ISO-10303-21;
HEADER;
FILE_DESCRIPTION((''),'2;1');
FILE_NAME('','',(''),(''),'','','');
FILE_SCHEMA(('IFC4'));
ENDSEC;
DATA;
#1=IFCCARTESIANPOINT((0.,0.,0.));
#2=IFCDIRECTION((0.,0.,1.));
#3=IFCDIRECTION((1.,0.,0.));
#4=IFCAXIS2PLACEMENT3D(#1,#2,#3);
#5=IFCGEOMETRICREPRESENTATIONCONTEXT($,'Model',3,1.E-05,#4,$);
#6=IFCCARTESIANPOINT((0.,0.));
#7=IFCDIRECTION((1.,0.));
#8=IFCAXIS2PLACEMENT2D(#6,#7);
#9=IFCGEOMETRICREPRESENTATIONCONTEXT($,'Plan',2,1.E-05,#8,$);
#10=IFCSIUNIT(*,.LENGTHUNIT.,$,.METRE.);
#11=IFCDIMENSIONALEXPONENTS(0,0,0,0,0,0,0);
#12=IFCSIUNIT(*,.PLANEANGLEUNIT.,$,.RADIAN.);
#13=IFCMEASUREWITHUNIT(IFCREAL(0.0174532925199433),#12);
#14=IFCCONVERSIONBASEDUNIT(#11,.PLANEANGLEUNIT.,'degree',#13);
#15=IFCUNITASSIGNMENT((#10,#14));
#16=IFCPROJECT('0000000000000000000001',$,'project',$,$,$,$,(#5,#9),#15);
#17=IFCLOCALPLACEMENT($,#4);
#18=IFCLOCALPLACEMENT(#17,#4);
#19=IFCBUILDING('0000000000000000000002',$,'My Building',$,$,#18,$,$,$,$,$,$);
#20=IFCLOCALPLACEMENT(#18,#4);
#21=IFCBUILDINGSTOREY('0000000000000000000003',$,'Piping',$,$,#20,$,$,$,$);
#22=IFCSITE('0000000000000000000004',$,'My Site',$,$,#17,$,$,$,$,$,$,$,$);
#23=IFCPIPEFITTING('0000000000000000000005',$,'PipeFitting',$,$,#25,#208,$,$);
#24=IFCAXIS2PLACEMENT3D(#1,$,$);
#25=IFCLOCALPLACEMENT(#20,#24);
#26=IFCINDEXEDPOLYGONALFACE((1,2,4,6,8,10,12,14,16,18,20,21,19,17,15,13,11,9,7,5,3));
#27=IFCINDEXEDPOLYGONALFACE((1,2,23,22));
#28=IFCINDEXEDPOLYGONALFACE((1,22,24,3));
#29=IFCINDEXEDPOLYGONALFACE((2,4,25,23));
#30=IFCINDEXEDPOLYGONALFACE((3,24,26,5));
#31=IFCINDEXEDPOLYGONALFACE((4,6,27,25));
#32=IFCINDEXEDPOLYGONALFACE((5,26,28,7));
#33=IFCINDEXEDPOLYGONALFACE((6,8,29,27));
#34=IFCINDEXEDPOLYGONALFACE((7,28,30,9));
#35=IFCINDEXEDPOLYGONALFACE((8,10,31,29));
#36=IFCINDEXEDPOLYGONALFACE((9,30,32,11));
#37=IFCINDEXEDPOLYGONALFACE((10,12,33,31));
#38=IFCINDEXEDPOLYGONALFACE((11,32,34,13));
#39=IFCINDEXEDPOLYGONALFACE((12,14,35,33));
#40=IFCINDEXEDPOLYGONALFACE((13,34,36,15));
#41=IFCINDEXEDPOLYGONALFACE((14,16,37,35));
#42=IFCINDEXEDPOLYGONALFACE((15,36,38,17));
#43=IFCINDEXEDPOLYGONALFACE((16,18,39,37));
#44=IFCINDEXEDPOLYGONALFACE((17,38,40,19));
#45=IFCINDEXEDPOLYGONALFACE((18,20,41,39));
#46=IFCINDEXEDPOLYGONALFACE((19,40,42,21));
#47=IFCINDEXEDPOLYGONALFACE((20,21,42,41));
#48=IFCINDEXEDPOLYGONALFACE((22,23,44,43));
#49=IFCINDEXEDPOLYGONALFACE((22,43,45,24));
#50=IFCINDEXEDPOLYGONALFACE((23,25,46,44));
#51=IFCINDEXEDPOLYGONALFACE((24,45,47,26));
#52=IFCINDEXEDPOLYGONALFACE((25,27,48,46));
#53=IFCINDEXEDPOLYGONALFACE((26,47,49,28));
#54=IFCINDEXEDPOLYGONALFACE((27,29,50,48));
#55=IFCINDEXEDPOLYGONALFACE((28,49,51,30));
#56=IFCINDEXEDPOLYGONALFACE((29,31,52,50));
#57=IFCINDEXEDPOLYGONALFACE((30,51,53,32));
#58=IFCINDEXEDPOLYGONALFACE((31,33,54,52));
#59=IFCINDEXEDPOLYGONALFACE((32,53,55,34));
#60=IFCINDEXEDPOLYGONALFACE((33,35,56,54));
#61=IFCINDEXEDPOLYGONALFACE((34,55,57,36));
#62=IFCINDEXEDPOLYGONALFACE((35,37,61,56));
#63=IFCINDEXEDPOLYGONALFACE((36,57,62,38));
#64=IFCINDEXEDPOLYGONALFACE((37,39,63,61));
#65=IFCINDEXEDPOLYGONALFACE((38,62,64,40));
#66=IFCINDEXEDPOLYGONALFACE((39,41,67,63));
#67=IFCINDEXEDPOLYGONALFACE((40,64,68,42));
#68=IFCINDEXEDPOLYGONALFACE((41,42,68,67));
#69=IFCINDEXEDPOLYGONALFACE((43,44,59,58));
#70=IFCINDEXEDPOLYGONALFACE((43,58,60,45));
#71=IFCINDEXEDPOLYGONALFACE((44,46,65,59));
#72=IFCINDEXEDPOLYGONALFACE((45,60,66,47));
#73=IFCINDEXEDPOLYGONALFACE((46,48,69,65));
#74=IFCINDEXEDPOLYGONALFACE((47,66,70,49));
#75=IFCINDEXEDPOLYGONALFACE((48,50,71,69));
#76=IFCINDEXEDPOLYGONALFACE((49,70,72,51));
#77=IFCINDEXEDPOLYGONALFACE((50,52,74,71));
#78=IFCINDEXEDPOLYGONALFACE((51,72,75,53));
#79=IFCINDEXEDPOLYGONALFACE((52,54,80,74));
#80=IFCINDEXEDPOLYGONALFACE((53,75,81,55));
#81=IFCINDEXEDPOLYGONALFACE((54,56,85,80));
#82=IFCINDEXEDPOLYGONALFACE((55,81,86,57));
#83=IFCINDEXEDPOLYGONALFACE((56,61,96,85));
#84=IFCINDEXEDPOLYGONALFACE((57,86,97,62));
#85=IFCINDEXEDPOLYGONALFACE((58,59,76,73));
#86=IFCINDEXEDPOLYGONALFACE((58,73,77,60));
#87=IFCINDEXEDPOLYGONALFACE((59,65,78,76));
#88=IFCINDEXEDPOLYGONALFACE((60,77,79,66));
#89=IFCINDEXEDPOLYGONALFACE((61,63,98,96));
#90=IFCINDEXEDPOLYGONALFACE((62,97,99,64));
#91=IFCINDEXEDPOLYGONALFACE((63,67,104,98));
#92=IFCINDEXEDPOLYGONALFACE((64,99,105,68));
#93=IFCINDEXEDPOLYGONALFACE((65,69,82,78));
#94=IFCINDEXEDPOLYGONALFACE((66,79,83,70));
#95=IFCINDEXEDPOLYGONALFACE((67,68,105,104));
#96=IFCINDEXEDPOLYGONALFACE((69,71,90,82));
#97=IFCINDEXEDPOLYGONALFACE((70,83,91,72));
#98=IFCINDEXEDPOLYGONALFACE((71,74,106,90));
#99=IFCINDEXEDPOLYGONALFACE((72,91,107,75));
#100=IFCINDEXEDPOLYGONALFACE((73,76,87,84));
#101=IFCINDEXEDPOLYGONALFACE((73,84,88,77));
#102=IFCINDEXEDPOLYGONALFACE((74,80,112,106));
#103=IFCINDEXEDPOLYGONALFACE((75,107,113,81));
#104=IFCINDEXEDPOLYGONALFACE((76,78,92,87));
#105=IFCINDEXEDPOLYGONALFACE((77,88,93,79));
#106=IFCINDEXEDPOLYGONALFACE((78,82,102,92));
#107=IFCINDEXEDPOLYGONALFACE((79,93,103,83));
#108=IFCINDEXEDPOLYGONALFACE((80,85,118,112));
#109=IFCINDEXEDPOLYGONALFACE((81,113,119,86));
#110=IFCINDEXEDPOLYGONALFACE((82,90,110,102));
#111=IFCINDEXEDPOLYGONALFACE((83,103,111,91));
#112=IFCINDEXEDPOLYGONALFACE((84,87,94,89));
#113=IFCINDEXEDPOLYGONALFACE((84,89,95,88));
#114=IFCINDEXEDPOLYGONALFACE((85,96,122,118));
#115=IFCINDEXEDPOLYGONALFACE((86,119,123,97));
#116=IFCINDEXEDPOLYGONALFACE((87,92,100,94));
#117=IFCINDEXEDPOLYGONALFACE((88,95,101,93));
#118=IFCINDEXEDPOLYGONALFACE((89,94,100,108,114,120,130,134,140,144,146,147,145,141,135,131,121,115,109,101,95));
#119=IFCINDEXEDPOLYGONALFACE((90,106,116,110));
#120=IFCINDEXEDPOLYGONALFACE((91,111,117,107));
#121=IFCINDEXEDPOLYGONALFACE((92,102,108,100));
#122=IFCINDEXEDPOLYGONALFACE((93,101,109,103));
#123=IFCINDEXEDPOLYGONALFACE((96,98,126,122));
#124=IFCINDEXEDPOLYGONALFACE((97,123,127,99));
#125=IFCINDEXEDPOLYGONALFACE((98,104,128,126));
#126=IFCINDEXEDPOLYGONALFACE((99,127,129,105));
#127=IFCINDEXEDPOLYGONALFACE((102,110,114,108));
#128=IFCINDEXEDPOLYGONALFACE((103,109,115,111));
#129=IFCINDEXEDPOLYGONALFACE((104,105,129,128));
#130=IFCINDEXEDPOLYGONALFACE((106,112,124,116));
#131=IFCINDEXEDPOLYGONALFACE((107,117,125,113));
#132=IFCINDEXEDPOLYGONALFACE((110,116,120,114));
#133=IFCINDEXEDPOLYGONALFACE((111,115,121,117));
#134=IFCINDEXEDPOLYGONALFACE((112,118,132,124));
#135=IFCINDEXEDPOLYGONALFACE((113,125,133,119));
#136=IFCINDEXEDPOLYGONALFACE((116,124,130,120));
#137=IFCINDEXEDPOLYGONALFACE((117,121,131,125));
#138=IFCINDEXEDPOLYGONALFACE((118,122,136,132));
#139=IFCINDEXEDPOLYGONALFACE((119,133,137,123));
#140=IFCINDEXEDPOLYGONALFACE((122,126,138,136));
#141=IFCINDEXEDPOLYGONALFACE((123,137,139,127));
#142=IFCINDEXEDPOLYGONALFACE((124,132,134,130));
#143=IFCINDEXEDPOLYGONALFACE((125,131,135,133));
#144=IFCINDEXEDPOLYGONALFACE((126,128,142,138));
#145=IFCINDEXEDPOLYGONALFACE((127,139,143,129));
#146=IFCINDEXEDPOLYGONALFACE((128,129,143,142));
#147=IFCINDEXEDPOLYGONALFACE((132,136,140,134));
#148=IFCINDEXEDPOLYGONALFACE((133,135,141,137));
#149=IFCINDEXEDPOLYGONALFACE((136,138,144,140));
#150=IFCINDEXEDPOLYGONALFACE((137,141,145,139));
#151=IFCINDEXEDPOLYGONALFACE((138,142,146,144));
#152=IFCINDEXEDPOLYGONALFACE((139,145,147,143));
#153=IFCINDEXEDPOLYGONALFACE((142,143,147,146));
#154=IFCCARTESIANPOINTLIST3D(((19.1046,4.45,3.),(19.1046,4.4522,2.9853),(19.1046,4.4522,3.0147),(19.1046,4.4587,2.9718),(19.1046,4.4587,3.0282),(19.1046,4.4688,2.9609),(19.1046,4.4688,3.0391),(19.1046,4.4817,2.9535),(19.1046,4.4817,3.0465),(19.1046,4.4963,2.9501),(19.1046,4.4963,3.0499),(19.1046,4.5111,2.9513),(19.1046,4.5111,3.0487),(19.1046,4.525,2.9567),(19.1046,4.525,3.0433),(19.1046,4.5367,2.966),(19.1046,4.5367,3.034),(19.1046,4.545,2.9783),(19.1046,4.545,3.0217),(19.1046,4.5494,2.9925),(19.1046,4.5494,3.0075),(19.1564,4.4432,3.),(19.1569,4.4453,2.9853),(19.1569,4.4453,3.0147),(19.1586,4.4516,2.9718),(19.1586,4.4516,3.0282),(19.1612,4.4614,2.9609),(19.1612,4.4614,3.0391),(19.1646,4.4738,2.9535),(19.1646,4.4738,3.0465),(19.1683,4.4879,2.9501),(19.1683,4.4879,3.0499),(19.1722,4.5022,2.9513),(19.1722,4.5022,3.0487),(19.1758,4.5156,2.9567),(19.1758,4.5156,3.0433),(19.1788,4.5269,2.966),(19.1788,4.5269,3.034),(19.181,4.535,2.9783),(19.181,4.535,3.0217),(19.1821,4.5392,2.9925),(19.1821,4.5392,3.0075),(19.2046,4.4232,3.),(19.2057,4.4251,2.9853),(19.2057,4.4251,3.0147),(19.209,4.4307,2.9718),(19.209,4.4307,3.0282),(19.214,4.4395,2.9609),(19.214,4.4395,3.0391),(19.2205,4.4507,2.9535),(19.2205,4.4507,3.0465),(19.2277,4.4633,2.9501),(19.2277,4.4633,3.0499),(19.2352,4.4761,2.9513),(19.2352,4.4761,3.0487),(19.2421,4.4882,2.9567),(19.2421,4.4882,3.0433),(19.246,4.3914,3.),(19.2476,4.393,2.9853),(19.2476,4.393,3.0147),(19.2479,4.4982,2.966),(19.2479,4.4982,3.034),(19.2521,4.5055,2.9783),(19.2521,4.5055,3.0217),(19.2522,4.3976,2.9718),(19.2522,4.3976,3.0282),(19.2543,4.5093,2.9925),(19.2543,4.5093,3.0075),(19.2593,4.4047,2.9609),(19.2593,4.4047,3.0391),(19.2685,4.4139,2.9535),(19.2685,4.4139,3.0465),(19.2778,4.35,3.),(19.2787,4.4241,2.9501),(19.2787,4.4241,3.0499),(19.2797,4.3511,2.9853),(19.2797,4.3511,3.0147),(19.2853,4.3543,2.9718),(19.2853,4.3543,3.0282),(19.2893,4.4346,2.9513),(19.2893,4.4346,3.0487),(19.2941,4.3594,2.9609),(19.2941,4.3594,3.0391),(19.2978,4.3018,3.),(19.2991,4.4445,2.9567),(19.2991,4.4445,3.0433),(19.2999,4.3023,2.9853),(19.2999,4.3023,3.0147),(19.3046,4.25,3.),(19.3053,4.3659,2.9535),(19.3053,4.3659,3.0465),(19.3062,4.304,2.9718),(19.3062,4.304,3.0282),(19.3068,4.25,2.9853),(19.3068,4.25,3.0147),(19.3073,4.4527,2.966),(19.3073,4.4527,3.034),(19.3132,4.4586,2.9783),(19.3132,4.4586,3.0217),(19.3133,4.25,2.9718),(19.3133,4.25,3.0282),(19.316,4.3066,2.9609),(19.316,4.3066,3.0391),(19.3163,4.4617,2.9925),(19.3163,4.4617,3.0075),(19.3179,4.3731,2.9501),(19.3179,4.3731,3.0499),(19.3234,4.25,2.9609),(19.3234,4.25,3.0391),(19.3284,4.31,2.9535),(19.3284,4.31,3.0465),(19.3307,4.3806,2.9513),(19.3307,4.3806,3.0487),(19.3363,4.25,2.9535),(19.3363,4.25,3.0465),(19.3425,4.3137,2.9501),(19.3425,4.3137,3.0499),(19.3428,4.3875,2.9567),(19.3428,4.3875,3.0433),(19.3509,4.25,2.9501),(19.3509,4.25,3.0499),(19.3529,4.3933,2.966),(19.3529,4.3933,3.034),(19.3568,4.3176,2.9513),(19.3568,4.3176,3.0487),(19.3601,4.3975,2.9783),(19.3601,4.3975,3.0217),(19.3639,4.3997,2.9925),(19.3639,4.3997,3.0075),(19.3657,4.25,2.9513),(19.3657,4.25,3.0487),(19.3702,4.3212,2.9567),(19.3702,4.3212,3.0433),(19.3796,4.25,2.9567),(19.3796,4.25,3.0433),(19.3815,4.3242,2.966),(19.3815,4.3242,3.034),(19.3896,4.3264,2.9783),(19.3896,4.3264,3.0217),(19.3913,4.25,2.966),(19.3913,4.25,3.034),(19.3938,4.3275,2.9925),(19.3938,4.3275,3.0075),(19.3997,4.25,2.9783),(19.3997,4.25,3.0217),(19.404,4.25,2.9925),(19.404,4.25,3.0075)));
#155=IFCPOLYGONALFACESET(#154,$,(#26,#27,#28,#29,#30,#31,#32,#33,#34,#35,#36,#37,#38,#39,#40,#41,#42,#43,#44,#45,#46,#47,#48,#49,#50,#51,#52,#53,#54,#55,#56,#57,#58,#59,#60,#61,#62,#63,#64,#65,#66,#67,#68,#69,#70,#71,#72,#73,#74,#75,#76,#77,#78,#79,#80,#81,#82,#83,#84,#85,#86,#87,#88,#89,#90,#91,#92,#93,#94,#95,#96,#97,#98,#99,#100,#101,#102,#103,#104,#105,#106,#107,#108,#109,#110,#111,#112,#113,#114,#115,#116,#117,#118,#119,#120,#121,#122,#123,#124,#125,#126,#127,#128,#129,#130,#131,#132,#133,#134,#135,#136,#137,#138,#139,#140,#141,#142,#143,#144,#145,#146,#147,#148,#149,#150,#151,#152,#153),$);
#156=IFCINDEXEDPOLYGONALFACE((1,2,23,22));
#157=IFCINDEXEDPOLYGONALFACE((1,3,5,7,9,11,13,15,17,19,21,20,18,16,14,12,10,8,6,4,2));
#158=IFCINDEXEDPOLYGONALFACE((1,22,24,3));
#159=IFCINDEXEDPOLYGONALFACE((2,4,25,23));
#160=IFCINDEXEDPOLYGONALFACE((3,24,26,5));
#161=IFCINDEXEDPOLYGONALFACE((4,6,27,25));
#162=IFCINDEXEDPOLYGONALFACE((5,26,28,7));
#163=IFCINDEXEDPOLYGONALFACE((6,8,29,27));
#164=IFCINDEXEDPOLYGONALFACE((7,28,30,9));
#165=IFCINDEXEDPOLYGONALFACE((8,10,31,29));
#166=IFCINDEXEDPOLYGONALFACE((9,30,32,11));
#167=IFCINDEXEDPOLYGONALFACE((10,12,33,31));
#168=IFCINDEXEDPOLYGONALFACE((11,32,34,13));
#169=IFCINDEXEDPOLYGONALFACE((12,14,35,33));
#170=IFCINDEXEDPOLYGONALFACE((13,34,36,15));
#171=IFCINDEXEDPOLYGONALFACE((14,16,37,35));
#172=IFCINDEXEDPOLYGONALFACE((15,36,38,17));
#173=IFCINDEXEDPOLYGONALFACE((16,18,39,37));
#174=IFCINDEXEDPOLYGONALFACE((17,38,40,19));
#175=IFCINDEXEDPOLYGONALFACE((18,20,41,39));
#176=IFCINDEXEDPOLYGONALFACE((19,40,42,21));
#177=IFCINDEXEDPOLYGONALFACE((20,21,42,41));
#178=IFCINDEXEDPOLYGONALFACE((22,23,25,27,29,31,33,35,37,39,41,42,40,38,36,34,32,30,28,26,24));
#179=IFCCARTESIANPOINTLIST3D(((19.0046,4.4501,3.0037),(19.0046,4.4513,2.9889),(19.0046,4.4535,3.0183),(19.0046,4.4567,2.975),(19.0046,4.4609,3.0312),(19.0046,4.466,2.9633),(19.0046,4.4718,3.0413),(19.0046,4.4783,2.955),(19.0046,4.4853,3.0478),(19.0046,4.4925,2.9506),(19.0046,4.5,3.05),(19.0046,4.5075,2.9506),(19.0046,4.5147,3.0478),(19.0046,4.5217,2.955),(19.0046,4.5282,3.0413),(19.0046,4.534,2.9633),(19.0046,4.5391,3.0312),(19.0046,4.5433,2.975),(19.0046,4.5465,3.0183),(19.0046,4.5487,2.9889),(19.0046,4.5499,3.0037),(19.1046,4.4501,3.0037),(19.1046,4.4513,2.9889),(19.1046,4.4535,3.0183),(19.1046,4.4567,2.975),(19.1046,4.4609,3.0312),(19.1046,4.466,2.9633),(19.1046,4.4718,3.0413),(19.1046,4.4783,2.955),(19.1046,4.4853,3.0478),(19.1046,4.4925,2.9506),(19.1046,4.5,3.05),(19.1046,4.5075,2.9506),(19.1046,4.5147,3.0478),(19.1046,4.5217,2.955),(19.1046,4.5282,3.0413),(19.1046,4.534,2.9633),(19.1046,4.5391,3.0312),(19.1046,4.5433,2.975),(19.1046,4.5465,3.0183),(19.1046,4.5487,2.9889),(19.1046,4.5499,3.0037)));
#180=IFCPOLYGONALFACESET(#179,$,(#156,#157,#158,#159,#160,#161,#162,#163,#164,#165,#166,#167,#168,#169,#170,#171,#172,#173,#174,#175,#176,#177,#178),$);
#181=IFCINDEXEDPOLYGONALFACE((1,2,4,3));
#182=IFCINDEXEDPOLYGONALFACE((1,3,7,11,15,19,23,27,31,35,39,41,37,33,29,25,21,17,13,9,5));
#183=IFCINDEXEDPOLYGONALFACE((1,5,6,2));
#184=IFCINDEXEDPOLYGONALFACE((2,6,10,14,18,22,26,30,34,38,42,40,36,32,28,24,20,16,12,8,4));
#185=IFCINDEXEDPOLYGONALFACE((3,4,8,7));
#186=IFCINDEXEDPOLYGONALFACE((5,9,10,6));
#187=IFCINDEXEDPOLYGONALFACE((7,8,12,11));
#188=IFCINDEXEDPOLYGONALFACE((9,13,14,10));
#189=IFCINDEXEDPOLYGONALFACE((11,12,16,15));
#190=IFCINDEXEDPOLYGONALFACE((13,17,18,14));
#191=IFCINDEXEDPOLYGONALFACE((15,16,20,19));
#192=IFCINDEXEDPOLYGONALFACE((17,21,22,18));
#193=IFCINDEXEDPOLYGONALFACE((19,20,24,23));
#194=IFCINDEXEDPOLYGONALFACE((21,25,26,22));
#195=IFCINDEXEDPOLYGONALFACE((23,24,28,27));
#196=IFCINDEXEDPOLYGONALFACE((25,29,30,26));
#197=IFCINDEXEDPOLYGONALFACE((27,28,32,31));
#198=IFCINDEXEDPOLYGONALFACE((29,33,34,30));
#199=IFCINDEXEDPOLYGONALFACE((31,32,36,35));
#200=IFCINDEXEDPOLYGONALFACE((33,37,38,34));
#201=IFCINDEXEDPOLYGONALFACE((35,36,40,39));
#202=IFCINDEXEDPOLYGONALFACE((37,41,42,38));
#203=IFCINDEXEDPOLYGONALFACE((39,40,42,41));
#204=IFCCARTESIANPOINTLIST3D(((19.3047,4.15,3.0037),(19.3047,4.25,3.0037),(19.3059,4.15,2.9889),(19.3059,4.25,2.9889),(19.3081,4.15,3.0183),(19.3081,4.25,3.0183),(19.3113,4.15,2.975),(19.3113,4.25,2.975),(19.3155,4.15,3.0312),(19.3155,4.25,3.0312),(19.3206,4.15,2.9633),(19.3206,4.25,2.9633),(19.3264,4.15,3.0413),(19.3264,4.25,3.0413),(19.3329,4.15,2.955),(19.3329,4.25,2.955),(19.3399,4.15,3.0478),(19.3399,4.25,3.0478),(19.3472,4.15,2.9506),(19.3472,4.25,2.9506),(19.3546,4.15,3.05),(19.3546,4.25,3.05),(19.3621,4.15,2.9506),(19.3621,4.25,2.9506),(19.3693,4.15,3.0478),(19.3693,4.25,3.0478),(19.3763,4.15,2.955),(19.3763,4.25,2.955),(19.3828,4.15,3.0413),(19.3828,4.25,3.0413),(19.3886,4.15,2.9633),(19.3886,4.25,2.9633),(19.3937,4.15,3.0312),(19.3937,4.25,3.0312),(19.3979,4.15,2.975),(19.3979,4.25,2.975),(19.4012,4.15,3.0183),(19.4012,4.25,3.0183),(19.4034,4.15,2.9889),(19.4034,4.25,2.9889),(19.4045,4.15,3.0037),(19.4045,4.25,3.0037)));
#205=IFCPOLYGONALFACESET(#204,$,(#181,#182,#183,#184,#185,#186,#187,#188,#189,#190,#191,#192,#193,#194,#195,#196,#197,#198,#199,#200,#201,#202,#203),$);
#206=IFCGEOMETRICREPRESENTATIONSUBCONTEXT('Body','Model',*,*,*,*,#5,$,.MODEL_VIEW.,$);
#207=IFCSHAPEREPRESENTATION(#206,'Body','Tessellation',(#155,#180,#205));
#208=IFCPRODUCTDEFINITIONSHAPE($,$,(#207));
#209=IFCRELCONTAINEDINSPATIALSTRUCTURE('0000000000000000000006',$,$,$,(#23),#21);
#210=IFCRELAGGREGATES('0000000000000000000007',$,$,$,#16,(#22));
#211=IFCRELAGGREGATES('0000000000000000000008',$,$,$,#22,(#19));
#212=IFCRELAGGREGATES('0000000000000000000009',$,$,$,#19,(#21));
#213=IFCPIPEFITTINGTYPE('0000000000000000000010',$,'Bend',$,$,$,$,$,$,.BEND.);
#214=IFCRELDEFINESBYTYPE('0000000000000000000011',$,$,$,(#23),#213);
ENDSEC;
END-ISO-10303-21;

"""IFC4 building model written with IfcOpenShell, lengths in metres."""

from ifc_helpers import new_model, entity, si_unit, converted_unit, frame, origin_with_axes, origin_2d_with_axis, place, context, subcontext, project, spatial, circle, extrude, source, transform, mapped, type_object, type_shapes, element, save


model = new_model("IFC4")

# Units and contexts
model_context = context("Model", 3, precision=1e-05, world=origin_with_axes())
plan_context = context("Plan", 2, precision=1e-05, world=origin_2d_with_axis())
body_context = subcontext(model_context, "Body", "Model", "MODEL_VIEW")
ifc_project = project(units=[si_unit("LENGTHUNIT", "METRE"), converted_unit("PLANEANGLEUNIT", "degree", entity("IfcReal", 0.0174532925199433), si_unit("PLANEANGLEUNIT", "RADIAN"), dimensions=[0, 0, 0, 0, 0, 0, 0])], contexts=[model_context, plan_context])

# Site, building, storey
site_placement = place(None, origin_with_axes())
site = spatial("IfcSite", under=ifc_project, at=site_placement, Name="My Site")
building_placement = place(site_placement, origin_with_axes())
building = spatial("IfcBuilding", under=site, at=building_placement, Name="My Building")
storey_placement = place(building_placement, origin_with_axes())
storey = spatial("IfcBuildingStorey", under=building, at=storey_placement, Name="Piping")

# Pipe fitting
pipe_fitting_type = type_object("IfcPipeFittingType", Name="Bend", PredefinedType="BEND")
shared_shape = source(origin_with_axes(), body_context, "Body", "SolidModel", [
    entity("IfcSweptDiskSolid", entity("IfcIndexedPolyCurve", entity("IfcCartesianPointList3D", [[0.0, 0.0, -0.1], [0.0, -0.0732, -0.2768], [0.0, -0.25, -0.35]]), [entity("IfcArcIndex", [1, 2, 3])]), 0.05),
    extrude(circle(Radius=0.05), origin_with_axes(), (0.0, 0.0, -1.0), 0.1),
    extrude(circle(Radius=0.05), frame((0.0, -0.25, -0.35), z_axis=(0.0, -1.0, 0.0), x_axis=(1.0, 0.0, 0.0)), (0.0, 0.0, 1.0), 0.1),
])
type_shapes(pipe_fitting_type, [shared_shape])
for number, where, z_axis, x_axis, name in (
    (1, (19.0046, 4.5, 3.0), (-1.0, -0.000001, 0.000001), (0.000001, 0.0, 1.0), "PipeFitting"),
):
    element("IfcPipeFitting", number, at=place(storey_placement, frame(where, z_axis=z_axis, x_axis=x_axis)), inside=storey, type_object=pipe_fitting_type, Name=name, context=body_context, shape_type="MappedRepresentation", body=[
        mapped(shared_shape, transform((0.0, 0.0, 0.0), x_axis=(1.0, 0.0, 0.0), y_axis=(0.0, 1.0, 0.0), z_axis=(0.0, 0.0, 1.0), scale=1.0)),
    ])

save(model, "model.ifc")
